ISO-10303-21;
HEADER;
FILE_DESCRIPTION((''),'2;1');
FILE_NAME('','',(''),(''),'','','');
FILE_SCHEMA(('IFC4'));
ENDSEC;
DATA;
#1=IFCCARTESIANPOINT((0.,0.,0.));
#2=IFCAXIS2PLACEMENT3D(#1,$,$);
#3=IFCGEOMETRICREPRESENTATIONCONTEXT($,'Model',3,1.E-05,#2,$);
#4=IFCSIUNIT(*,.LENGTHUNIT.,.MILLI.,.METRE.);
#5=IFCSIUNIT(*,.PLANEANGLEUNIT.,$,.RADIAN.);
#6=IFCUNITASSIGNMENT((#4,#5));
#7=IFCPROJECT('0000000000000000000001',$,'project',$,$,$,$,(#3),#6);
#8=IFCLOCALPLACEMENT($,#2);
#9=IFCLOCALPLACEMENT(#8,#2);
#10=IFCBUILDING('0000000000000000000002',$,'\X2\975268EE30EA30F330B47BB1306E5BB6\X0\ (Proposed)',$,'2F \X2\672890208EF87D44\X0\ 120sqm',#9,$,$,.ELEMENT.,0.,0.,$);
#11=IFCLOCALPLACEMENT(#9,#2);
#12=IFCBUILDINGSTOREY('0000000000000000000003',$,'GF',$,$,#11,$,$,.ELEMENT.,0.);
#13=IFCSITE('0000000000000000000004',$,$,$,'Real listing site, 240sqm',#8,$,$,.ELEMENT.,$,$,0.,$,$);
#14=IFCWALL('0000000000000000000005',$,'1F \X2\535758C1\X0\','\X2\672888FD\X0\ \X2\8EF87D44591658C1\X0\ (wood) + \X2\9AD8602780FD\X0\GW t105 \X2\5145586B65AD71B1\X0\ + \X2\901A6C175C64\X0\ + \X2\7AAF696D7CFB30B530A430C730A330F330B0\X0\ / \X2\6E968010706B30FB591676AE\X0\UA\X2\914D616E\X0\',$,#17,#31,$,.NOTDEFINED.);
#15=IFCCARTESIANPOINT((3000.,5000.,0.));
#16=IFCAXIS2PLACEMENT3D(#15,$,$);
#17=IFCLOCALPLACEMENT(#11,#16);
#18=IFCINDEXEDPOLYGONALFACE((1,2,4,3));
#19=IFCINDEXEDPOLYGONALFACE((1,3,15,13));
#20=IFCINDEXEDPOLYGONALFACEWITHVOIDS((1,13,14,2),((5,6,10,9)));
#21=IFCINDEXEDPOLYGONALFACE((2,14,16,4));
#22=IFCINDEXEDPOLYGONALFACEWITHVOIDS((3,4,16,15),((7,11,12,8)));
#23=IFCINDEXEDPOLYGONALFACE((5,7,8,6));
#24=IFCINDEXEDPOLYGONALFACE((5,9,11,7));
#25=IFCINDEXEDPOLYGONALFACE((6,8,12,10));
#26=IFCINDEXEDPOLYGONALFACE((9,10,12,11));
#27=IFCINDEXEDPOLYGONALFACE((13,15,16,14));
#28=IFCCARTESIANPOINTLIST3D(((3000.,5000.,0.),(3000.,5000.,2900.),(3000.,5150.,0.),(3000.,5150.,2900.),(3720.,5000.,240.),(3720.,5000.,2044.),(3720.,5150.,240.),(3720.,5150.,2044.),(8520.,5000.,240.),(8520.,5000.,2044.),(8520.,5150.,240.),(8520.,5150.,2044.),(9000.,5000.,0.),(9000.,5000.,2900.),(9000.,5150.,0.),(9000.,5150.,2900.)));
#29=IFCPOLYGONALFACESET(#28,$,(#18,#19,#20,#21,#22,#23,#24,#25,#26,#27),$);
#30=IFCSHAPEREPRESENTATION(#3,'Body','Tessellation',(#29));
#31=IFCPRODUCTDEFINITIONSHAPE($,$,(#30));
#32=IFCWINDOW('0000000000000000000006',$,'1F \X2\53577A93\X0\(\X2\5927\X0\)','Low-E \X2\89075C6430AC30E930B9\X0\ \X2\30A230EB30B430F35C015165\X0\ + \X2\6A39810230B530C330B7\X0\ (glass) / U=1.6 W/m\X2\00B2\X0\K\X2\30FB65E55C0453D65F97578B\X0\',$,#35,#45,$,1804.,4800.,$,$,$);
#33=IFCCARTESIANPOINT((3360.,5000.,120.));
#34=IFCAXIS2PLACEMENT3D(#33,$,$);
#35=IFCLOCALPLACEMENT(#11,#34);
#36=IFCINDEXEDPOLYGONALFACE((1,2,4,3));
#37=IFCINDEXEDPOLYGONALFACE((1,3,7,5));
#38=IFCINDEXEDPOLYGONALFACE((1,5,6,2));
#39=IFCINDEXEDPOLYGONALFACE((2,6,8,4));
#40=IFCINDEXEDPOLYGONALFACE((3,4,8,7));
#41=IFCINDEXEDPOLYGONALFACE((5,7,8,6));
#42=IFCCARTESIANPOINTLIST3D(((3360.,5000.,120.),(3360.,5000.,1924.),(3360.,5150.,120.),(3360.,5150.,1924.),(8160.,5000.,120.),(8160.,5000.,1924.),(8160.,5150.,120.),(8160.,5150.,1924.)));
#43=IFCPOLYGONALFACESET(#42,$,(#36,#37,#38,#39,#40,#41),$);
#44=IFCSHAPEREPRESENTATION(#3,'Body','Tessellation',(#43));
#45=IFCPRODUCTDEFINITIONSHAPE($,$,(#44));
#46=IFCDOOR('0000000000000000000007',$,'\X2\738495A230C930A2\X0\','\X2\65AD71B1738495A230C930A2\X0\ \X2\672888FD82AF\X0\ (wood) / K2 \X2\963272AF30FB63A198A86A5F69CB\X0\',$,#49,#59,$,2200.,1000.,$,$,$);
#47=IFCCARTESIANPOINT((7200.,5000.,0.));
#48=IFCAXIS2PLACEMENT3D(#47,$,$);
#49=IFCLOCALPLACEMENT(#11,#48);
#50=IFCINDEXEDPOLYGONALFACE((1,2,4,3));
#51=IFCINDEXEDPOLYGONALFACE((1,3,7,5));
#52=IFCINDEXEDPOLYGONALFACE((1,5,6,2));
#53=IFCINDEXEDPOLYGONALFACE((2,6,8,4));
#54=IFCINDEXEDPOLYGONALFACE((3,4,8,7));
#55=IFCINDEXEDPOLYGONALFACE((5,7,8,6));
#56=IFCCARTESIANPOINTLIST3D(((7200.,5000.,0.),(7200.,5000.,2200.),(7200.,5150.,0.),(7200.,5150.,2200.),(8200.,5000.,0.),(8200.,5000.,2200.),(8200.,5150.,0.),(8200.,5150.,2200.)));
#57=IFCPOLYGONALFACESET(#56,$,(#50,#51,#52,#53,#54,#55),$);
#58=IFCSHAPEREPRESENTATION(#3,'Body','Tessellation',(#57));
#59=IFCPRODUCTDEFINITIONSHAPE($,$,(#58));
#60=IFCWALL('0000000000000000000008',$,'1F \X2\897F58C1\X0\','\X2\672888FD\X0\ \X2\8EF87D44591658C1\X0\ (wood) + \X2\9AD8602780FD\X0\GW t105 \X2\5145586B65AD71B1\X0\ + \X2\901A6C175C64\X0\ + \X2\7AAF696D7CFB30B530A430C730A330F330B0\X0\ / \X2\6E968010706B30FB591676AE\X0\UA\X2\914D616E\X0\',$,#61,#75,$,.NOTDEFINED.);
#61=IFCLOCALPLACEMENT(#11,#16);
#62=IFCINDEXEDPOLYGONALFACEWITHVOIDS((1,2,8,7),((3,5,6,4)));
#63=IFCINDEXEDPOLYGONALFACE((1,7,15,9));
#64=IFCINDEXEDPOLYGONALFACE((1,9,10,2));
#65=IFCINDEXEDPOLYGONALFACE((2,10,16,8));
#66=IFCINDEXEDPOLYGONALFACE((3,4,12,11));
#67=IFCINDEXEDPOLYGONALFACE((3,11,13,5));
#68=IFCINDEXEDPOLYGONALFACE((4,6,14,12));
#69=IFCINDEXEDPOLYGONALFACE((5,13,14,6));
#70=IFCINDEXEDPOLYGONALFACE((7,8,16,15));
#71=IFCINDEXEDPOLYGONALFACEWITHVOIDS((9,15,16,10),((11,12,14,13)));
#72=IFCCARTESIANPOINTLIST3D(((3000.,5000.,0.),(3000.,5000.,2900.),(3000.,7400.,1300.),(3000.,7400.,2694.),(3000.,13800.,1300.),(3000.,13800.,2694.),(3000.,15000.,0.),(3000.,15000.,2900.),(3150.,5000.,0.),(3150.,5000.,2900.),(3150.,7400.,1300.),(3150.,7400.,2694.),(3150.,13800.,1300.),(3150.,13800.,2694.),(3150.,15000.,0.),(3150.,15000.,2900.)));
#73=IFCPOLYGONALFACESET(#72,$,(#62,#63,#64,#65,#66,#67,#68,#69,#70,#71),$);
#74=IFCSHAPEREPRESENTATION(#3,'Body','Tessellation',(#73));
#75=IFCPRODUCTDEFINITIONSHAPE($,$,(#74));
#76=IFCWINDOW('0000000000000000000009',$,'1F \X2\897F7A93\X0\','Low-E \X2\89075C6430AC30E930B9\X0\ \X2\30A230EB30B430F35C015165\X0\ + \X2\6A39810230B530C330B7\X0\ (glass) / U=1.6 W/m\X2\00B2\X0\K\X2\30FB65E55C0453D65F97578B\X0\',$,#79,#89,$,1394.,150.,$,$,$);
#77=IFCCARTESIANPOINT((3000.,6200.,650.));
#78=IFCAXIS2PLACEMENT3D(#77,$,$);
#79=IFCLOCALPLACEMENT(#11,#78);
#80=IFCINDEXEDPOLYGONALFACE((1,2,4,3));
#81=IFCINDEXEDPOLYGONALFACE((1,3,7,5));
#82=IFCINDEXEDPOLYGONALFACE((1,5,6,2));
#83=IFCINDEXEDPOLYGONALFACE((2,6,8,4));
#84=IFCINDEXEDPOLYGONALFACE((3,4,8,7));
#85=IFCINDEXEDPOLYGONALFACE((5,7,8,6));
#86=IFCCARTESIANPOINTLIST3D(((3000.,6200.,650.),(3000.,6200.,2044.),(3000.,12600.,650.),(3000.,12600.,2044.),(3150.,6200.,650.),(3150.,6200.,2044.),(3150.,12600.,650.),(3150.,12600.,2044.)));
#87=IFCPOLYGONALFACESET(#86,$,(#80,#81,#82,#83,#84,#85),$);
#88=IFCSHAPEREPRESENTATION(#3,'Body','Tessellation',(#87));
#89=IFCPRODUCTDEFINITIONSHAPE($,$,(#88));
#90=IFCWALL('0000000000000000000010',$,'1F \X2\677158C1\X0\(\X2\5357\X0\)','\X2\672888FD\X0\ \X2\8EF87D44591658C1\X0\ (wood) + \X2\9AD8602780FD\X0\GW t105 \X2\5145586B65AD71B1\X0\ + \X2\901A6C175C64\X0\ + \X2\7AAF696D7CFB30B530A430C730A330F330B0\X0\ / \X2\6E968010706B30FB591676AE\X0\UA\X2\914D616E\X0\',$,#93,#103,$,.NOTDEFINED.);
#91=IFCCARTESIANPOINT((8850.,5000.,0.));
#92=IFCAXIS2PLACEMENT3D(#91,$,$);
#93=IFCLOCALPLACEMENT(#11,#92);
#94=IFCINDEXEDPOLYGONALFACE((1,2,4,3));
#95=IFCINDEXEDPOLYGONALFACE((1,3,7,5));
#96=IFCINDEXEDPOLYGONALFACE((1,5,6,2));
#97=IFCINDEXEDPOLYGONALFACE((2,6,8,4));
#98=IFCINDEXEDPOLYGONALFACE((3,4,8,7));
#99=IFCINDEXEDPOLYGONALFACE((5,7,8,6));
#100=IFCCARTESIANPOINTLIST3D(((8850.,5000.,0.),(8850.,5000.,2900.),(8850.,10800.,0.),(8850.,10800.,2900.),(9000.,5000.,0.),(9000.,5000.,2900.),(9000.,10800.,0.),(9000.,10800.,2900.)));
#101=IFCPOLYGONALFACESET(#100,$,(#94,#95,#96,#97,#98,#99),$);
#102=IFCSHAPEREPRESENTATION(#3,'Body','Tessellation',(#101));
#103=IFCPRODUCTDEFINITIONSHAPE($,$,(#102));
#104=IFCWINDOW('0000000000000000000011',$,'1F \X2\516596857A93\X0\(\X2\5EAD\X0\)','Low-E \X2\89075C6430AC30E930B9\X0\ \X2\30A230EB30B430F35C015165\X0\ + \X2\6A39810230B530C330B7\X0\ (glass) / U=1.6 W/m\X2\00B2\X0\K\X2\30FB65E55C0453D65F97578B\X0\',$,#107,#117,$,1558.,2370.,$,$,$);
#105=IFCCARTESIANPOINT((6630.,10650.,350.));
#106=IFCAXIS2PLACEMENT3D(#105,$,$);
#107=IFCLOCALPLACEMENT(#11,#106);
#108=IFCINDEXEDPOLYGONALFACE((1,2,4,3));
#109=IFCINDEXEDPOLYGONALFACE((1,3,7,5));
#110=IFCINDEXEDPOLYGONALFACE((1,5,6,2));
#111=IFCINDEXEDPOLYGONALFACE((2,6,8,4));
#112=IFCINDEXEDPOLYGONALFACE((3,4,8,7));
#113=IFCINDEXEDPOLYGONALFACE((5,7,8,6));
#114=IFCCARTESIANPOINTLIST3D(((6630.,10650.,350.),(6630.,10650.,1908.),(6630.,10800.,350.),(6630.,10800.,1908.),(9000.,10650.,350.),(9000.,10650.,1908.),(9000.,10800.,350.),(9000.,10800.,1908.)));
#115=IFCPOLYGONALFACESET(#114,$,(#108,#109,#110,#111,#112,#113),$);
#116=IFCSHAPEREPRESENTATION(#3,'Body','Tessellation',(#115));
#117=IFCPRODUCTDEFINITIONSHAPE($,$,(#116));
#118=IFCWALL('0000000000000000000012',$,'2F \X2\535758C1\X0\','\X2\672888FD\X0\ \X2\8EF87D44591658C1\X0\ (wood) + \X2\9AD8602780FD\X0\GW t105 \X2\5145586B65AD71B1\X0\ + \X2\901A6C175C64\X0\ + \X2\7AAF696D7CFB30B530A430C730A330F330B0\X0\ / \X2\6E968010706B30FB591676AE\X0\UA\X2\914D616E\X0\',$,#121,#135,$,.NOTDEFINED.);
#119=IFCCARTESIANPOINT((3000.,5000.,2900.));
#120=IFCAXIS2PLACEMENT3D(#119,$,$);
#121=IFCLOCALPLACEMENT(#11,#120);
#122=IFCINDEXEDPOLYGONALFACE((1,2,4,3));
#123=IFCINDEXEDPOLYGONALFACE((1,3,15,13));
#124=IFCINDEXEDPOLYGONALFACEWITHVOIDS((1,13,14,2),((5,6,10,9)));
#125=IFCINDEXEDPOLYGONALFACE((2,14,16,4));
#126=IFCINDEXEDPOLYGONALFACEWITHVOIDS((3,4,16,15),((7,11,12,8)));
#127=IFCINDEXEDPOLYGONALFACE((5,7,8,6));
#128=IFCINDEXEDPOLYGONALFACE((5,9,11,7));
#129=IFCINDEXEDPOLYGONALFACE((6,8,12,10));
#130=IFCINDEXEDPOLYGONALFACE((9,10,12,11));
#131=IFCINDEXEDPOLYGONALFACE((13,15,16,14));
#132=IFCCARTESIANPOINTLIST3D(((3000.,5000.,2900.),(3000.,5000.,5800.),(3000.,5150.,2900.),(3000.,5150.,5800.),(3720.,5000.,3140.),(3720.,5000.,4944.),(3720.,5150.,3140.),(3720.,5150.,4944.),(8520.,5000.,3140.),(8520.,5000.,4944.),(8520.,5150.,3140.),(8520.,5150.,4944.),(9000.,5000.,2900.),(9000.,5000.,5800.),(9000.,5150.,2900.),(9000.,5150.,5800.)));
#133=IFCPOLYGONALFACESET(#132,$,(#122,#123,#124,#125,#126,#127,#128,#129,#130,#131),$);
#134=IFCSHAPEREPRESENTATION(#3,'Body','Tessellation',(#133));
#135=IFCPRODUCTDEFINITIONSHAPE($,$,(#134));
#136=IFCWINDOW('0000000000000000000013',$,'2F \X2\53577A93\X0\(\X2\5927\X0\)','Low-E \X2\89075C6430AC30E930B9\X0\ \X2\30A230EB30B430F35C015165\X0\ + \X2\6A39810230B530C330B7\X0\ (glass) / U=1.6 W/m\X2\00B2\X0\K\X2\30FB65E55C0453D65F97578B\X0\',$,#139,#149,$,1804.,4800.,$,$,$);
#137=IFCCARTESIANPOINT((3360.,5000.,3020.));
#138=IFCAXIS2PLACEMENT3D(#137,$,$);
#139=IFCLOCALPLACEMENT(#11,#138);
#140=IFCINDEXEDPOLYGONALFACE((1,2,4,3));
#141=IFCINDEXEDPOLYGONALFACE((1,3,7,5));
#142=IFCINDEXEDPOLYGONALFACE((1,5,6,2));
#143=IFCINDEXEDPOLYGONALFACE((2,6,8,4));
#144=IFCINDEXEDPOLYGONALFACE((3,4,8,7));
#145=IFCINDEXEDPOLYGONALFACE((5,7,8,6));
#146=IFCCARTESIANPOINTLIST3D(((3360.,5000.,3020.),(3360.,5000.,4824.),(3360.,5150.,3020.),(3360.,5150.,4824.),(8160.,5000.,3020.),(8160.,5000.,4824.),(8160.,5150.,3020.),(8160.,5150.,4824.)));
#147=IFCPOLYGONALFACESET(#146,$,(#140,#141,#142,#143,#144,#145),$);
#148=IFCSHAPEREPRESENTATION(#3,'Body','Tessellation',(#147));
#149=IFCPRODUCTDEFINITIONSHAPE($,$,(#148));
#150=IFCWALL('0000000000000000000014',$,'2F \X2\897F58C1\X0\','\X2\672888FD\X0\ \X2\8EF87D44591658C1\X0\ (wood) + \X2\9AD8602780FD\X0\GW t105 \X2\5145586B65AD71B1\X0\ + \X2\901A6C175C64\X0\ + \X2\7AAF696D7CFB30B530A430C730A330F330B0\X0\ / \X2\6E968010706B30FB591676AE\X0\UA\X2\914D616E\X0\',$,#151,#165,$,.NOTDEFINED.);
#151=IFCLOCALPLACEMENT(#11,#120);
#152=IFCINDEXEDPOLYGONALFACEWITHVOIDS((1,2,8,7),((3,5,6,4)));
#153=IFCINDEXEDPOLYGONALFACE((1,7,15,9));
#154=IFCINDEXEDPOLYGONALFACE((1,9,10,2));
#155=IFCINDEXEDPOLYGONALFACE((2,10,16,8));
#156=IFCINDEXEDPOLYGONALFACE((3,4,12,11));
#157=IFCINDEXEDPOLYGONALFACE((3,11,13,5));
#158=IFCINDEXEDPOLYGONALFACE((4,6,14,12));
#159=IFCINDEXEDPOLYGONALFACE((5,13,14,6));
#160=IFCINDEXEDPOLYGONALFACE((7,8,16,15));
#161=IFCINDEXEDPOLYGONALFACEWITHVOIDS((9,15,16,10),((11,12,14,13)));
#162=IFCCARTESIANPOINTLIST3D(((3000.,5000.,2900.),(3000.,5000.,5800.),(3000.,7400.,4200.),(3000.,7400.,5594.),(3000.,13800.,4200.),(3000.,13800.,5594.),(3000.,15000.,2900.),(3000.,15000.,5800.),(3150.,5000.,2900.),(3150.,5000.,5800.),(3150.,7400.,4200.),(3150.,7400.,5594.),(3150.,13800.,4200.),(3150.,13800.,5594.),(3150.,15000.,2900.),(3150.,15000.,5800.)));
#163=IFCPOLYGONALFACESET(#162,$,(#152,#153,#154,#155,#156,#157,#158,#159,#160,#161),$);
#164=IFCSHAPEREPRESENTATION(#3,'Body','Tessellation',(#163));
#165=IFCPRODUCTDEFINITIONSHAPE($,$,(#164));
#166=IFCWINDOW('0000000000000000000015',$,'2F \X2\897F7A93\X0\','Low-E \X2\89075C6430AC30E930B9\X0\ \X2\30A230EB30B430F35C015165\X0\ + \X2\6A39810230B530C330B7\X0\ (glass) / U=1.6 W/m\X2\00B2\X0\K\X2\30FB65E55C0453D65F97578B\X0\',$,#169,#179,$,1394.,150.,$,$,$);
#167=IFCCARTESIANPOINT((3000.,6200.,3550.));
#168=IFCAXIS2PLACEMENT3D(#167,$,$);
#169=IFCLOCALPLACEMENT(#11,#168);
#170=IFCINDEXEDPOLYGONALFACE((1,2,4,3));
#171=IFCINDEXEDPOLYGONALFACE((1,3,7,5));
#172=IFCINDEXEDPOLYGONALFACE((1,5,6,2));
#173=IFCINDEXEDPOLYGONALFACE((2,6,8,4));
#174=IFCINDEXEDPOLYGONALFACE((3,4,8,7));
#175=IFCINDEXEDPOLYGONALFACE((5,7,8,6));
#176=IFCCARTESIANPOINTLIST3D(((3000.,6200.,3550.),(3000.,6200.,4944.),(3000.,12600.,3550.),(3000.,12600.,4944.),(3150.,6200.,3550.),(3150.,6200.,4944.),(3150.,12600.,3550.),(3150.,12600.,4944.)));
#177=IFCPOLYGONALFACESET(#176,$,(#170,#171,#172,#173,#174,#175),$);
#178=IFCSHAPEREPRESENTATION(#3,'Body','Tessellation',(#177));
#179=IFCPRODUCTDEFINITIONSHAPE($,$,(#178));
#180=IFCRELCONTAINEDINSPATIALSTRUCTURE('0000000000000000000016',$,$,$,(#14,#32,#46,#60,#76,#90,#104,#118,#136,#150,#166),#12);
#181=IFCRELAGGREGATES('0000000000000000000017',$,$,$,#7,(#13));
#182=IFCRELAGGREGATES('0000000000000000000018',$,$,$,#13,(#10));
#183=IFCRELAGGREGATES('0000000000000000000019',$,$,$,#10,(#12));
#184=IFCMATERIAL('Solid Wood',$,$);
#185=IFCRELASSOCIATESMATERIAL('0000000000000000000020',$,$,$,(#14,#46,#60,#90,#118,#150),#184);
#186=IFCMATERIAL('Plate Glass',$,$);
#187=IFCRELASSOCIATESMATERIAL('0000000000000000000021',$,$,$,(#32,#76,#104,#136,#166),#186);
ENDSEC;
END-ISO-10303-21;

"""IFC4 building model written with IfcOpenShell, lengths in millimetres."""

from ifc_helpers import new_model, si_unit, frame, frame_2d, origin, place, context, project, spatial, rectangle, extrude, material, element, fill, save


model = new_model("IFC4")

# Units and contexts
model_context = context("Model", 3, precision=1e-05, world=origin())
ifc_project = project(units=[si_unit("LENGTHUNIT", "METRE", prefix="MILLI"), si_unit("PLANEANGLEUNIT", "RADIAN")], contexts=[model_context])

# Site, building, storey
site_placement = place(None, origin())
site = spatial("IfcSite", under=ifc_project, at=site_placement, ObjectType="Real listing site, 240sqm", CompositionType="ELEMENT", RefElevation=0.0)
building_placement = place(site_placement, origin())
building = spatial("IfcBuilding", under=site, at=building_placement, Name="青森リンゴ箱の家 (Proposed)", ObjectType="2F 木造軸組 120sqm", CompositionType="ELEMENT", ElevationOfRefHeight=0.0, ElevationOfTerrain=0.0)
storey_placement = place(building_placement, origin())
storey = spatial("IfcBuildingStorey", under=building, at=storey_placement, Name="GF", CompositionType="ELEMENT", Elevation=0.0)

# Shared definitions
ifc_material_1 = material(Name="Solid Wood")

# Wall, openings, window, door
wall_1_placement = place(storey_placement, frame((3000.0, 5000.0, 0.0)))
wall_1 = element("IfcWall", 1, at=wall_1_placement, inside=storey, material=ifc_material_1, Name="1F 南壁", Description="木製 軸組外壁 (wood) + 高性能GW t105 充填断熱 + 通気層 + 窯業系サイディング / 準耐火・外皮UA配慮", PredefinedType="NOTDEFINED", context=model_context, shape_type="SweptSolid", body=[
    extrude(rectangle(XDim=6000.0, YDim=150.0, at=frame_2d((3000.0, 75.0))), frame((3000.0, 5000.0, 0.0)), (0.0, 0.0, 1.0), 2900.0),
])
opening_1_placement = place(storey_placement, frame((3360.0, 5000.0, 120.0)))
opening_1 = element("IfcOpeningElement", 2, at=opening_1_placement, cuts=wall_1, PredefinedType="NOTDEFINED", context=model_context, shape_type="SweptSolid", body=[
    extrude(rectangle(XDim=4800.0, YDim=150.0, at=frame_2d((2400.0, 75.0))), frame((3360.0, 5000.0, 120.0)), (0.0, 0.0, 1.0), 1804.0),
])
opening_2_placement = place(storey_placement, frame((7200.0, 5000.0, 0.0)))
opening_2 = element("IfcOpeningElement", 3, at=opening_2_placement, cuts=wall_1, PredefinedType="NOTDEFINED", context=model_context, shape_type="SweptSolid", body=[
    extrude(rectangle(XDim=1000.0, YDim=150.0, at=frame_2d((500.0, 75.0))), frame((7200.0, 5000.0, 0.0)), (0.0, 0.0, 1.0), 2200.0),
])
ifc_material_2 = material(Name="Plate Glass")
window_1_placement = place(storey_placement, frame((3360.0, 5000.0, 120.0)))
window_1 = element("IfcWindow", 4, at=window_1_placement, inside=storey, material=ifc_material_2, Name="1F 南窓(大)", Description="Low-E 複層ガラス アルゴン封入 + 樹脂サッシ (glass) / U=1.6 W/m²K・日射取得型", OverallHeight=1804.0, OverallWidth=4800.0, context=model_context, shape_type="SweptSolid", body=[
    extrude(rectangle(XDim=4800.0, YDim=150.0, at=frame_2d((2400.0, 75.0))), frame((3360.0, 5000.0, 120.0)), (0.0, 0.0, 1.0), 1804.0),
])
fill(opening_1, window_1)
door_placement = place(storey_placement, frame((7200.0, 5000.0, 0.0)))
door = element("IfcDoor", 5, at=door_placement, inside=storey, material=ifc_material_1, Name="玄関ドア", Description="断熱玄関ドア 木製芯 (wood) / K2 防犯・採風機構", OverallHeight=2200.0, OverallWidth=1000.0, context=model_context, shape_type="SweptSolid", body=[
    extrude(rectangle(XDim=1000.0, YDim=150.0, at=frame_2d((500.0, 75.0))), frame((7200.0, 5000.0, 0.0)), (0.0, 0.0, 1.0), 2200.0),
])
fill(opening_2, door)

# Walls, openings, windows
wall_2_placement = place(storey_placement, frame((3000.0, 5000.0, 0.0)))
wall_2 = element("IfcWall", 6, at=wall_2_placement, inside=storey, material=ifc_material_1, Name="1F 西壁", Description="木製 軸組外壁 (wood) + 高性能GW t105 充填断熱 + 通気層 + 窯業系サイディング / 準耐火・外皮UA配慮", PredefinedType="NOTDEFINED", context=model_context, shape_type="SweptSolid", body=[
    extrude(rectangle(XDim=150.0, YDim=10000.0, at=frame_2d((75.0, 5000.0))), frame((3000.0, 5000.0, 0.0)), (0.0, 0.0, 1.0), 2900.0),
])
opening_3_placement = place(storey_placement, frame((3000.0, 6200.0, 650.0)))
opening_3 = element("IfcOpeningElement", 7, at=opening_3_placement, cuts=wall_2, PredefinedType="NOTDEFINED", context=model_context, shape_type="SweptSolid", body=[
    extrude(rectangle(XDim=150.0, YDim=6400.0, at=frame_2d((75.0, 3200.0))), frame((3000.0, 6200.0, 650.0)), (0.0, 0.0, 1.0), 1394.0),
])
window_2_placement = place(storey_placement, frame((3000.0, 6200.0, 650.0)))
window_2 = element("IfcWindow", 8, at=window_2_placement, inside=storey, material=ifc_material_2, Name="1F 西窓", Description="Low-E 複層ガラス アルゴン封入 + 樹脂サッシ (glass) / U=1.6 W/m²K・日射取得型", OverallHeight=1394.0, OverallWidth=150.0, context=model_context, shape_type="SweptSolid", body=[
    extrude(rectangle(XDim=150.0, YDim=6400.0, at=frame_2d((75.0, 3200.0))), frame((3000.0, 6200.0, 650.0)), (0.0, 0.0, 1.0), 1394.0),
])
fill(opening_3, window_2)
wall_3_placement = place(storey_placement, frame((8850.0, 5000.0, 0.0)))
wall_3 = element("IfcWall", 9, at=wall_3_placement, inside=storey, material=ifc_material_1, Name="1F 東壁(南)", Description="木製 軸組外壁 (wood) + 高性能GW t105 充填断熱 + 通気層 + 窯業系サイディング / 準耐火・外皮UA配慮", PredefinedType="NOTDEFINED", context=model_context, shape_type="SweptSolid", body=[
    extrude(rectangle(XDim=150.0, YDim=5800.0, at=frame_2d((75.0, 2900.0))), frame((8850.0, 5000.0, 0.0)), (0.0, 0.0, 1.0), 2900.0),
])
opening_4_placement = place(storey_placement, frame((6630.0, 10650.0, 350.0)))
opening_4 = element("IfcOpeningElement", 10, at=opening_4_placement, cuts=wall_3, PredefinedType="NOTDEFINED", context=model_context, shape_type="SweptSolid", body=[
    extrude(rectangle(XDim=2370.0, YDim=150.0, at=frame_2d((1185.0, 75.0))), frame((6630.0, 10650.0, 350.0)), (0.0, 0.0, 1.0), 1558.0),
])
window_3_placement = place(storey_placement, frame((6630.0, 10650.0, 350.0)))
window_3 = element("IfcWindow", 11, at=window_3_placement, inside=storey, material=ifc_material_2, Name="1F 入隅窓(庭)", Description="Low-E 複層ガラス アルゴン封入 + 樹脂サッシ (glass) / U=1.6 W/m²K・日射取得型", OverallHeight=1558.0, OverallWidth=2370.0, context=model_context, shape_type="SweptSolid", body=[
    extrude(rectangle(XDim=2370.0, YDim=150.0, at=frame_2d((1185.0, 75.0))), frame((6630.0, 10650.0, 350.0)), (0.0, 0.0, 1.0), 1558.0),
])
fill(opening_4, window_3)

# Walls, openings, windows
wall_4_placement = place(storey_placement, frame((3000.0, 5000.0, 2900.0)))
wall_4 = element("IfcWall", 12, at=wall_4_placement, inside=storey, material=ifc_material_1, Name="2F 南壁", Description="木製 軸組外壁 (wood) + 高性能GW t105 充填断熱 + 通気層 + 窯業系サイディング / 準耐火・外皮UA配慮", PredefinedType="NOTDEFINED", context=model_context, shape_type="SweptSolid", body=[
    extrude(rectangle(XDim=6000.0, YDim=150.0, at=frame_2d((3000.0, 75.0))), frame((3000.0, 5000.0, 2900.0)), (0.0, 0.0, 1.0), 2900.0),
])
opening_5_placement = place(storey_placement, frame((3360.0, 5000.0, 3020.0)))
opening_5 = element("IfcOpeningElement", 13, at=opening_5_placement, cuts=wall_4, PredefinedType="NOTDEFINED", context=model_context, shape_type="SweptSolid", body=[
    extrude(rectangle(XDim=4800.0, YDim=150.0, at=frame_2d((2400.0, 75.0))), frame((3360.0, 5000.0, 3020.0)), (0.0, 0.0, 1.0), 1804.0),
])
window_4_placement = place(storey_placement, frame((3360.0, 5000.0, 3020.0)))
window_4 = element("IfcWindow", 14, at=window_4_placement, inside=storey, material=ifc_material_2, Name="2F 南窓(大)", Description="Low-E 複層ガラス アルゴン封入 + 樹脂サッシ (glass) / U=1.6 W/m²K・日射取得型", OverallHeight=1804.0, OverallWidth=4800.0, context=model_context, shape_type="SweptSolid", body=[
    extrude(rectangle(XDim=4800.0, YDim=150.0, at=frame_2d((2400.0, 75.0))), frame((3360.0, 5000.0, 3020.0)), (0.0, 0.0, 1.0), 1804.0),
])
fill(opening_5, window_4)
wall_5_placement = place(storey_placement, frame((3000.0, 5000.0, 2900.0)))
wall_5 = element("IfcWall", 15, at=wall_5_placement, inside=storey, material=ifc_material_1, Name="2F 西壁", Description="木製 軸組外壁 (wood) + 高性能GW t105 充填断熱 + 通気層 + 窯業系サイディング / 準耐火・外皮UA配慮", PredefinedType="NOTDEFINED", context=model_context, shape_type="SweptSolid", body=[
    extrude(rectangle(XDim=150.0, YDim=10000.0, at=frame_2d((75.0, 5000.0))), frame((3000.0, 5000.0, 2900.0)), (0.0, 0.0, 1.0), 2900.0),
])
opening_6_placement = place(storey_placement, frame((3000.0, 6200.0, 3550.0)))
opening_6 = element("IfcOpeningElement", 16, at=opening_6_placement, cuts=wall_5, PredefinedType="NOTDEFINED", context=model_context, shape_type="SweptSolid", body=[
    extrude(rectangle(XDim=150.0, YDim=6400.0, at=frame_2d((75.0, 3200.0))), frame((3000.0, 6200.0, 3550.0)), (0.0, 0.0, 1.0), 1394.0),
])
window_5_placement = place(storey_placement, frame((3000.0, 6200.0, 3550.0)))
window_5 = element("IfcWindow", 17, at=window_5_placement, inside=storey, material=ifc_material_2, Name="2F 西窓", Description="Low-E 複層ガラス アルゴン封入 + 樹脂サッシ (glass) / U=1.6 W/m²K・日射取得型", OverallHeight=1394.0, OverallWidth=150.0, context=model_context, shape_type="SweptSolid", body=[
    extrude(rectangle(XDim=150.0, YDim=6400.0, at=frame_2d((75.0, 3200.0))), frame((3000.0, 6200.0, 3550.0)), (0.0, 0.0, 1.0), 1394.0),
])
fill(opening_6, window_5)

save(model, "model.ifc")
